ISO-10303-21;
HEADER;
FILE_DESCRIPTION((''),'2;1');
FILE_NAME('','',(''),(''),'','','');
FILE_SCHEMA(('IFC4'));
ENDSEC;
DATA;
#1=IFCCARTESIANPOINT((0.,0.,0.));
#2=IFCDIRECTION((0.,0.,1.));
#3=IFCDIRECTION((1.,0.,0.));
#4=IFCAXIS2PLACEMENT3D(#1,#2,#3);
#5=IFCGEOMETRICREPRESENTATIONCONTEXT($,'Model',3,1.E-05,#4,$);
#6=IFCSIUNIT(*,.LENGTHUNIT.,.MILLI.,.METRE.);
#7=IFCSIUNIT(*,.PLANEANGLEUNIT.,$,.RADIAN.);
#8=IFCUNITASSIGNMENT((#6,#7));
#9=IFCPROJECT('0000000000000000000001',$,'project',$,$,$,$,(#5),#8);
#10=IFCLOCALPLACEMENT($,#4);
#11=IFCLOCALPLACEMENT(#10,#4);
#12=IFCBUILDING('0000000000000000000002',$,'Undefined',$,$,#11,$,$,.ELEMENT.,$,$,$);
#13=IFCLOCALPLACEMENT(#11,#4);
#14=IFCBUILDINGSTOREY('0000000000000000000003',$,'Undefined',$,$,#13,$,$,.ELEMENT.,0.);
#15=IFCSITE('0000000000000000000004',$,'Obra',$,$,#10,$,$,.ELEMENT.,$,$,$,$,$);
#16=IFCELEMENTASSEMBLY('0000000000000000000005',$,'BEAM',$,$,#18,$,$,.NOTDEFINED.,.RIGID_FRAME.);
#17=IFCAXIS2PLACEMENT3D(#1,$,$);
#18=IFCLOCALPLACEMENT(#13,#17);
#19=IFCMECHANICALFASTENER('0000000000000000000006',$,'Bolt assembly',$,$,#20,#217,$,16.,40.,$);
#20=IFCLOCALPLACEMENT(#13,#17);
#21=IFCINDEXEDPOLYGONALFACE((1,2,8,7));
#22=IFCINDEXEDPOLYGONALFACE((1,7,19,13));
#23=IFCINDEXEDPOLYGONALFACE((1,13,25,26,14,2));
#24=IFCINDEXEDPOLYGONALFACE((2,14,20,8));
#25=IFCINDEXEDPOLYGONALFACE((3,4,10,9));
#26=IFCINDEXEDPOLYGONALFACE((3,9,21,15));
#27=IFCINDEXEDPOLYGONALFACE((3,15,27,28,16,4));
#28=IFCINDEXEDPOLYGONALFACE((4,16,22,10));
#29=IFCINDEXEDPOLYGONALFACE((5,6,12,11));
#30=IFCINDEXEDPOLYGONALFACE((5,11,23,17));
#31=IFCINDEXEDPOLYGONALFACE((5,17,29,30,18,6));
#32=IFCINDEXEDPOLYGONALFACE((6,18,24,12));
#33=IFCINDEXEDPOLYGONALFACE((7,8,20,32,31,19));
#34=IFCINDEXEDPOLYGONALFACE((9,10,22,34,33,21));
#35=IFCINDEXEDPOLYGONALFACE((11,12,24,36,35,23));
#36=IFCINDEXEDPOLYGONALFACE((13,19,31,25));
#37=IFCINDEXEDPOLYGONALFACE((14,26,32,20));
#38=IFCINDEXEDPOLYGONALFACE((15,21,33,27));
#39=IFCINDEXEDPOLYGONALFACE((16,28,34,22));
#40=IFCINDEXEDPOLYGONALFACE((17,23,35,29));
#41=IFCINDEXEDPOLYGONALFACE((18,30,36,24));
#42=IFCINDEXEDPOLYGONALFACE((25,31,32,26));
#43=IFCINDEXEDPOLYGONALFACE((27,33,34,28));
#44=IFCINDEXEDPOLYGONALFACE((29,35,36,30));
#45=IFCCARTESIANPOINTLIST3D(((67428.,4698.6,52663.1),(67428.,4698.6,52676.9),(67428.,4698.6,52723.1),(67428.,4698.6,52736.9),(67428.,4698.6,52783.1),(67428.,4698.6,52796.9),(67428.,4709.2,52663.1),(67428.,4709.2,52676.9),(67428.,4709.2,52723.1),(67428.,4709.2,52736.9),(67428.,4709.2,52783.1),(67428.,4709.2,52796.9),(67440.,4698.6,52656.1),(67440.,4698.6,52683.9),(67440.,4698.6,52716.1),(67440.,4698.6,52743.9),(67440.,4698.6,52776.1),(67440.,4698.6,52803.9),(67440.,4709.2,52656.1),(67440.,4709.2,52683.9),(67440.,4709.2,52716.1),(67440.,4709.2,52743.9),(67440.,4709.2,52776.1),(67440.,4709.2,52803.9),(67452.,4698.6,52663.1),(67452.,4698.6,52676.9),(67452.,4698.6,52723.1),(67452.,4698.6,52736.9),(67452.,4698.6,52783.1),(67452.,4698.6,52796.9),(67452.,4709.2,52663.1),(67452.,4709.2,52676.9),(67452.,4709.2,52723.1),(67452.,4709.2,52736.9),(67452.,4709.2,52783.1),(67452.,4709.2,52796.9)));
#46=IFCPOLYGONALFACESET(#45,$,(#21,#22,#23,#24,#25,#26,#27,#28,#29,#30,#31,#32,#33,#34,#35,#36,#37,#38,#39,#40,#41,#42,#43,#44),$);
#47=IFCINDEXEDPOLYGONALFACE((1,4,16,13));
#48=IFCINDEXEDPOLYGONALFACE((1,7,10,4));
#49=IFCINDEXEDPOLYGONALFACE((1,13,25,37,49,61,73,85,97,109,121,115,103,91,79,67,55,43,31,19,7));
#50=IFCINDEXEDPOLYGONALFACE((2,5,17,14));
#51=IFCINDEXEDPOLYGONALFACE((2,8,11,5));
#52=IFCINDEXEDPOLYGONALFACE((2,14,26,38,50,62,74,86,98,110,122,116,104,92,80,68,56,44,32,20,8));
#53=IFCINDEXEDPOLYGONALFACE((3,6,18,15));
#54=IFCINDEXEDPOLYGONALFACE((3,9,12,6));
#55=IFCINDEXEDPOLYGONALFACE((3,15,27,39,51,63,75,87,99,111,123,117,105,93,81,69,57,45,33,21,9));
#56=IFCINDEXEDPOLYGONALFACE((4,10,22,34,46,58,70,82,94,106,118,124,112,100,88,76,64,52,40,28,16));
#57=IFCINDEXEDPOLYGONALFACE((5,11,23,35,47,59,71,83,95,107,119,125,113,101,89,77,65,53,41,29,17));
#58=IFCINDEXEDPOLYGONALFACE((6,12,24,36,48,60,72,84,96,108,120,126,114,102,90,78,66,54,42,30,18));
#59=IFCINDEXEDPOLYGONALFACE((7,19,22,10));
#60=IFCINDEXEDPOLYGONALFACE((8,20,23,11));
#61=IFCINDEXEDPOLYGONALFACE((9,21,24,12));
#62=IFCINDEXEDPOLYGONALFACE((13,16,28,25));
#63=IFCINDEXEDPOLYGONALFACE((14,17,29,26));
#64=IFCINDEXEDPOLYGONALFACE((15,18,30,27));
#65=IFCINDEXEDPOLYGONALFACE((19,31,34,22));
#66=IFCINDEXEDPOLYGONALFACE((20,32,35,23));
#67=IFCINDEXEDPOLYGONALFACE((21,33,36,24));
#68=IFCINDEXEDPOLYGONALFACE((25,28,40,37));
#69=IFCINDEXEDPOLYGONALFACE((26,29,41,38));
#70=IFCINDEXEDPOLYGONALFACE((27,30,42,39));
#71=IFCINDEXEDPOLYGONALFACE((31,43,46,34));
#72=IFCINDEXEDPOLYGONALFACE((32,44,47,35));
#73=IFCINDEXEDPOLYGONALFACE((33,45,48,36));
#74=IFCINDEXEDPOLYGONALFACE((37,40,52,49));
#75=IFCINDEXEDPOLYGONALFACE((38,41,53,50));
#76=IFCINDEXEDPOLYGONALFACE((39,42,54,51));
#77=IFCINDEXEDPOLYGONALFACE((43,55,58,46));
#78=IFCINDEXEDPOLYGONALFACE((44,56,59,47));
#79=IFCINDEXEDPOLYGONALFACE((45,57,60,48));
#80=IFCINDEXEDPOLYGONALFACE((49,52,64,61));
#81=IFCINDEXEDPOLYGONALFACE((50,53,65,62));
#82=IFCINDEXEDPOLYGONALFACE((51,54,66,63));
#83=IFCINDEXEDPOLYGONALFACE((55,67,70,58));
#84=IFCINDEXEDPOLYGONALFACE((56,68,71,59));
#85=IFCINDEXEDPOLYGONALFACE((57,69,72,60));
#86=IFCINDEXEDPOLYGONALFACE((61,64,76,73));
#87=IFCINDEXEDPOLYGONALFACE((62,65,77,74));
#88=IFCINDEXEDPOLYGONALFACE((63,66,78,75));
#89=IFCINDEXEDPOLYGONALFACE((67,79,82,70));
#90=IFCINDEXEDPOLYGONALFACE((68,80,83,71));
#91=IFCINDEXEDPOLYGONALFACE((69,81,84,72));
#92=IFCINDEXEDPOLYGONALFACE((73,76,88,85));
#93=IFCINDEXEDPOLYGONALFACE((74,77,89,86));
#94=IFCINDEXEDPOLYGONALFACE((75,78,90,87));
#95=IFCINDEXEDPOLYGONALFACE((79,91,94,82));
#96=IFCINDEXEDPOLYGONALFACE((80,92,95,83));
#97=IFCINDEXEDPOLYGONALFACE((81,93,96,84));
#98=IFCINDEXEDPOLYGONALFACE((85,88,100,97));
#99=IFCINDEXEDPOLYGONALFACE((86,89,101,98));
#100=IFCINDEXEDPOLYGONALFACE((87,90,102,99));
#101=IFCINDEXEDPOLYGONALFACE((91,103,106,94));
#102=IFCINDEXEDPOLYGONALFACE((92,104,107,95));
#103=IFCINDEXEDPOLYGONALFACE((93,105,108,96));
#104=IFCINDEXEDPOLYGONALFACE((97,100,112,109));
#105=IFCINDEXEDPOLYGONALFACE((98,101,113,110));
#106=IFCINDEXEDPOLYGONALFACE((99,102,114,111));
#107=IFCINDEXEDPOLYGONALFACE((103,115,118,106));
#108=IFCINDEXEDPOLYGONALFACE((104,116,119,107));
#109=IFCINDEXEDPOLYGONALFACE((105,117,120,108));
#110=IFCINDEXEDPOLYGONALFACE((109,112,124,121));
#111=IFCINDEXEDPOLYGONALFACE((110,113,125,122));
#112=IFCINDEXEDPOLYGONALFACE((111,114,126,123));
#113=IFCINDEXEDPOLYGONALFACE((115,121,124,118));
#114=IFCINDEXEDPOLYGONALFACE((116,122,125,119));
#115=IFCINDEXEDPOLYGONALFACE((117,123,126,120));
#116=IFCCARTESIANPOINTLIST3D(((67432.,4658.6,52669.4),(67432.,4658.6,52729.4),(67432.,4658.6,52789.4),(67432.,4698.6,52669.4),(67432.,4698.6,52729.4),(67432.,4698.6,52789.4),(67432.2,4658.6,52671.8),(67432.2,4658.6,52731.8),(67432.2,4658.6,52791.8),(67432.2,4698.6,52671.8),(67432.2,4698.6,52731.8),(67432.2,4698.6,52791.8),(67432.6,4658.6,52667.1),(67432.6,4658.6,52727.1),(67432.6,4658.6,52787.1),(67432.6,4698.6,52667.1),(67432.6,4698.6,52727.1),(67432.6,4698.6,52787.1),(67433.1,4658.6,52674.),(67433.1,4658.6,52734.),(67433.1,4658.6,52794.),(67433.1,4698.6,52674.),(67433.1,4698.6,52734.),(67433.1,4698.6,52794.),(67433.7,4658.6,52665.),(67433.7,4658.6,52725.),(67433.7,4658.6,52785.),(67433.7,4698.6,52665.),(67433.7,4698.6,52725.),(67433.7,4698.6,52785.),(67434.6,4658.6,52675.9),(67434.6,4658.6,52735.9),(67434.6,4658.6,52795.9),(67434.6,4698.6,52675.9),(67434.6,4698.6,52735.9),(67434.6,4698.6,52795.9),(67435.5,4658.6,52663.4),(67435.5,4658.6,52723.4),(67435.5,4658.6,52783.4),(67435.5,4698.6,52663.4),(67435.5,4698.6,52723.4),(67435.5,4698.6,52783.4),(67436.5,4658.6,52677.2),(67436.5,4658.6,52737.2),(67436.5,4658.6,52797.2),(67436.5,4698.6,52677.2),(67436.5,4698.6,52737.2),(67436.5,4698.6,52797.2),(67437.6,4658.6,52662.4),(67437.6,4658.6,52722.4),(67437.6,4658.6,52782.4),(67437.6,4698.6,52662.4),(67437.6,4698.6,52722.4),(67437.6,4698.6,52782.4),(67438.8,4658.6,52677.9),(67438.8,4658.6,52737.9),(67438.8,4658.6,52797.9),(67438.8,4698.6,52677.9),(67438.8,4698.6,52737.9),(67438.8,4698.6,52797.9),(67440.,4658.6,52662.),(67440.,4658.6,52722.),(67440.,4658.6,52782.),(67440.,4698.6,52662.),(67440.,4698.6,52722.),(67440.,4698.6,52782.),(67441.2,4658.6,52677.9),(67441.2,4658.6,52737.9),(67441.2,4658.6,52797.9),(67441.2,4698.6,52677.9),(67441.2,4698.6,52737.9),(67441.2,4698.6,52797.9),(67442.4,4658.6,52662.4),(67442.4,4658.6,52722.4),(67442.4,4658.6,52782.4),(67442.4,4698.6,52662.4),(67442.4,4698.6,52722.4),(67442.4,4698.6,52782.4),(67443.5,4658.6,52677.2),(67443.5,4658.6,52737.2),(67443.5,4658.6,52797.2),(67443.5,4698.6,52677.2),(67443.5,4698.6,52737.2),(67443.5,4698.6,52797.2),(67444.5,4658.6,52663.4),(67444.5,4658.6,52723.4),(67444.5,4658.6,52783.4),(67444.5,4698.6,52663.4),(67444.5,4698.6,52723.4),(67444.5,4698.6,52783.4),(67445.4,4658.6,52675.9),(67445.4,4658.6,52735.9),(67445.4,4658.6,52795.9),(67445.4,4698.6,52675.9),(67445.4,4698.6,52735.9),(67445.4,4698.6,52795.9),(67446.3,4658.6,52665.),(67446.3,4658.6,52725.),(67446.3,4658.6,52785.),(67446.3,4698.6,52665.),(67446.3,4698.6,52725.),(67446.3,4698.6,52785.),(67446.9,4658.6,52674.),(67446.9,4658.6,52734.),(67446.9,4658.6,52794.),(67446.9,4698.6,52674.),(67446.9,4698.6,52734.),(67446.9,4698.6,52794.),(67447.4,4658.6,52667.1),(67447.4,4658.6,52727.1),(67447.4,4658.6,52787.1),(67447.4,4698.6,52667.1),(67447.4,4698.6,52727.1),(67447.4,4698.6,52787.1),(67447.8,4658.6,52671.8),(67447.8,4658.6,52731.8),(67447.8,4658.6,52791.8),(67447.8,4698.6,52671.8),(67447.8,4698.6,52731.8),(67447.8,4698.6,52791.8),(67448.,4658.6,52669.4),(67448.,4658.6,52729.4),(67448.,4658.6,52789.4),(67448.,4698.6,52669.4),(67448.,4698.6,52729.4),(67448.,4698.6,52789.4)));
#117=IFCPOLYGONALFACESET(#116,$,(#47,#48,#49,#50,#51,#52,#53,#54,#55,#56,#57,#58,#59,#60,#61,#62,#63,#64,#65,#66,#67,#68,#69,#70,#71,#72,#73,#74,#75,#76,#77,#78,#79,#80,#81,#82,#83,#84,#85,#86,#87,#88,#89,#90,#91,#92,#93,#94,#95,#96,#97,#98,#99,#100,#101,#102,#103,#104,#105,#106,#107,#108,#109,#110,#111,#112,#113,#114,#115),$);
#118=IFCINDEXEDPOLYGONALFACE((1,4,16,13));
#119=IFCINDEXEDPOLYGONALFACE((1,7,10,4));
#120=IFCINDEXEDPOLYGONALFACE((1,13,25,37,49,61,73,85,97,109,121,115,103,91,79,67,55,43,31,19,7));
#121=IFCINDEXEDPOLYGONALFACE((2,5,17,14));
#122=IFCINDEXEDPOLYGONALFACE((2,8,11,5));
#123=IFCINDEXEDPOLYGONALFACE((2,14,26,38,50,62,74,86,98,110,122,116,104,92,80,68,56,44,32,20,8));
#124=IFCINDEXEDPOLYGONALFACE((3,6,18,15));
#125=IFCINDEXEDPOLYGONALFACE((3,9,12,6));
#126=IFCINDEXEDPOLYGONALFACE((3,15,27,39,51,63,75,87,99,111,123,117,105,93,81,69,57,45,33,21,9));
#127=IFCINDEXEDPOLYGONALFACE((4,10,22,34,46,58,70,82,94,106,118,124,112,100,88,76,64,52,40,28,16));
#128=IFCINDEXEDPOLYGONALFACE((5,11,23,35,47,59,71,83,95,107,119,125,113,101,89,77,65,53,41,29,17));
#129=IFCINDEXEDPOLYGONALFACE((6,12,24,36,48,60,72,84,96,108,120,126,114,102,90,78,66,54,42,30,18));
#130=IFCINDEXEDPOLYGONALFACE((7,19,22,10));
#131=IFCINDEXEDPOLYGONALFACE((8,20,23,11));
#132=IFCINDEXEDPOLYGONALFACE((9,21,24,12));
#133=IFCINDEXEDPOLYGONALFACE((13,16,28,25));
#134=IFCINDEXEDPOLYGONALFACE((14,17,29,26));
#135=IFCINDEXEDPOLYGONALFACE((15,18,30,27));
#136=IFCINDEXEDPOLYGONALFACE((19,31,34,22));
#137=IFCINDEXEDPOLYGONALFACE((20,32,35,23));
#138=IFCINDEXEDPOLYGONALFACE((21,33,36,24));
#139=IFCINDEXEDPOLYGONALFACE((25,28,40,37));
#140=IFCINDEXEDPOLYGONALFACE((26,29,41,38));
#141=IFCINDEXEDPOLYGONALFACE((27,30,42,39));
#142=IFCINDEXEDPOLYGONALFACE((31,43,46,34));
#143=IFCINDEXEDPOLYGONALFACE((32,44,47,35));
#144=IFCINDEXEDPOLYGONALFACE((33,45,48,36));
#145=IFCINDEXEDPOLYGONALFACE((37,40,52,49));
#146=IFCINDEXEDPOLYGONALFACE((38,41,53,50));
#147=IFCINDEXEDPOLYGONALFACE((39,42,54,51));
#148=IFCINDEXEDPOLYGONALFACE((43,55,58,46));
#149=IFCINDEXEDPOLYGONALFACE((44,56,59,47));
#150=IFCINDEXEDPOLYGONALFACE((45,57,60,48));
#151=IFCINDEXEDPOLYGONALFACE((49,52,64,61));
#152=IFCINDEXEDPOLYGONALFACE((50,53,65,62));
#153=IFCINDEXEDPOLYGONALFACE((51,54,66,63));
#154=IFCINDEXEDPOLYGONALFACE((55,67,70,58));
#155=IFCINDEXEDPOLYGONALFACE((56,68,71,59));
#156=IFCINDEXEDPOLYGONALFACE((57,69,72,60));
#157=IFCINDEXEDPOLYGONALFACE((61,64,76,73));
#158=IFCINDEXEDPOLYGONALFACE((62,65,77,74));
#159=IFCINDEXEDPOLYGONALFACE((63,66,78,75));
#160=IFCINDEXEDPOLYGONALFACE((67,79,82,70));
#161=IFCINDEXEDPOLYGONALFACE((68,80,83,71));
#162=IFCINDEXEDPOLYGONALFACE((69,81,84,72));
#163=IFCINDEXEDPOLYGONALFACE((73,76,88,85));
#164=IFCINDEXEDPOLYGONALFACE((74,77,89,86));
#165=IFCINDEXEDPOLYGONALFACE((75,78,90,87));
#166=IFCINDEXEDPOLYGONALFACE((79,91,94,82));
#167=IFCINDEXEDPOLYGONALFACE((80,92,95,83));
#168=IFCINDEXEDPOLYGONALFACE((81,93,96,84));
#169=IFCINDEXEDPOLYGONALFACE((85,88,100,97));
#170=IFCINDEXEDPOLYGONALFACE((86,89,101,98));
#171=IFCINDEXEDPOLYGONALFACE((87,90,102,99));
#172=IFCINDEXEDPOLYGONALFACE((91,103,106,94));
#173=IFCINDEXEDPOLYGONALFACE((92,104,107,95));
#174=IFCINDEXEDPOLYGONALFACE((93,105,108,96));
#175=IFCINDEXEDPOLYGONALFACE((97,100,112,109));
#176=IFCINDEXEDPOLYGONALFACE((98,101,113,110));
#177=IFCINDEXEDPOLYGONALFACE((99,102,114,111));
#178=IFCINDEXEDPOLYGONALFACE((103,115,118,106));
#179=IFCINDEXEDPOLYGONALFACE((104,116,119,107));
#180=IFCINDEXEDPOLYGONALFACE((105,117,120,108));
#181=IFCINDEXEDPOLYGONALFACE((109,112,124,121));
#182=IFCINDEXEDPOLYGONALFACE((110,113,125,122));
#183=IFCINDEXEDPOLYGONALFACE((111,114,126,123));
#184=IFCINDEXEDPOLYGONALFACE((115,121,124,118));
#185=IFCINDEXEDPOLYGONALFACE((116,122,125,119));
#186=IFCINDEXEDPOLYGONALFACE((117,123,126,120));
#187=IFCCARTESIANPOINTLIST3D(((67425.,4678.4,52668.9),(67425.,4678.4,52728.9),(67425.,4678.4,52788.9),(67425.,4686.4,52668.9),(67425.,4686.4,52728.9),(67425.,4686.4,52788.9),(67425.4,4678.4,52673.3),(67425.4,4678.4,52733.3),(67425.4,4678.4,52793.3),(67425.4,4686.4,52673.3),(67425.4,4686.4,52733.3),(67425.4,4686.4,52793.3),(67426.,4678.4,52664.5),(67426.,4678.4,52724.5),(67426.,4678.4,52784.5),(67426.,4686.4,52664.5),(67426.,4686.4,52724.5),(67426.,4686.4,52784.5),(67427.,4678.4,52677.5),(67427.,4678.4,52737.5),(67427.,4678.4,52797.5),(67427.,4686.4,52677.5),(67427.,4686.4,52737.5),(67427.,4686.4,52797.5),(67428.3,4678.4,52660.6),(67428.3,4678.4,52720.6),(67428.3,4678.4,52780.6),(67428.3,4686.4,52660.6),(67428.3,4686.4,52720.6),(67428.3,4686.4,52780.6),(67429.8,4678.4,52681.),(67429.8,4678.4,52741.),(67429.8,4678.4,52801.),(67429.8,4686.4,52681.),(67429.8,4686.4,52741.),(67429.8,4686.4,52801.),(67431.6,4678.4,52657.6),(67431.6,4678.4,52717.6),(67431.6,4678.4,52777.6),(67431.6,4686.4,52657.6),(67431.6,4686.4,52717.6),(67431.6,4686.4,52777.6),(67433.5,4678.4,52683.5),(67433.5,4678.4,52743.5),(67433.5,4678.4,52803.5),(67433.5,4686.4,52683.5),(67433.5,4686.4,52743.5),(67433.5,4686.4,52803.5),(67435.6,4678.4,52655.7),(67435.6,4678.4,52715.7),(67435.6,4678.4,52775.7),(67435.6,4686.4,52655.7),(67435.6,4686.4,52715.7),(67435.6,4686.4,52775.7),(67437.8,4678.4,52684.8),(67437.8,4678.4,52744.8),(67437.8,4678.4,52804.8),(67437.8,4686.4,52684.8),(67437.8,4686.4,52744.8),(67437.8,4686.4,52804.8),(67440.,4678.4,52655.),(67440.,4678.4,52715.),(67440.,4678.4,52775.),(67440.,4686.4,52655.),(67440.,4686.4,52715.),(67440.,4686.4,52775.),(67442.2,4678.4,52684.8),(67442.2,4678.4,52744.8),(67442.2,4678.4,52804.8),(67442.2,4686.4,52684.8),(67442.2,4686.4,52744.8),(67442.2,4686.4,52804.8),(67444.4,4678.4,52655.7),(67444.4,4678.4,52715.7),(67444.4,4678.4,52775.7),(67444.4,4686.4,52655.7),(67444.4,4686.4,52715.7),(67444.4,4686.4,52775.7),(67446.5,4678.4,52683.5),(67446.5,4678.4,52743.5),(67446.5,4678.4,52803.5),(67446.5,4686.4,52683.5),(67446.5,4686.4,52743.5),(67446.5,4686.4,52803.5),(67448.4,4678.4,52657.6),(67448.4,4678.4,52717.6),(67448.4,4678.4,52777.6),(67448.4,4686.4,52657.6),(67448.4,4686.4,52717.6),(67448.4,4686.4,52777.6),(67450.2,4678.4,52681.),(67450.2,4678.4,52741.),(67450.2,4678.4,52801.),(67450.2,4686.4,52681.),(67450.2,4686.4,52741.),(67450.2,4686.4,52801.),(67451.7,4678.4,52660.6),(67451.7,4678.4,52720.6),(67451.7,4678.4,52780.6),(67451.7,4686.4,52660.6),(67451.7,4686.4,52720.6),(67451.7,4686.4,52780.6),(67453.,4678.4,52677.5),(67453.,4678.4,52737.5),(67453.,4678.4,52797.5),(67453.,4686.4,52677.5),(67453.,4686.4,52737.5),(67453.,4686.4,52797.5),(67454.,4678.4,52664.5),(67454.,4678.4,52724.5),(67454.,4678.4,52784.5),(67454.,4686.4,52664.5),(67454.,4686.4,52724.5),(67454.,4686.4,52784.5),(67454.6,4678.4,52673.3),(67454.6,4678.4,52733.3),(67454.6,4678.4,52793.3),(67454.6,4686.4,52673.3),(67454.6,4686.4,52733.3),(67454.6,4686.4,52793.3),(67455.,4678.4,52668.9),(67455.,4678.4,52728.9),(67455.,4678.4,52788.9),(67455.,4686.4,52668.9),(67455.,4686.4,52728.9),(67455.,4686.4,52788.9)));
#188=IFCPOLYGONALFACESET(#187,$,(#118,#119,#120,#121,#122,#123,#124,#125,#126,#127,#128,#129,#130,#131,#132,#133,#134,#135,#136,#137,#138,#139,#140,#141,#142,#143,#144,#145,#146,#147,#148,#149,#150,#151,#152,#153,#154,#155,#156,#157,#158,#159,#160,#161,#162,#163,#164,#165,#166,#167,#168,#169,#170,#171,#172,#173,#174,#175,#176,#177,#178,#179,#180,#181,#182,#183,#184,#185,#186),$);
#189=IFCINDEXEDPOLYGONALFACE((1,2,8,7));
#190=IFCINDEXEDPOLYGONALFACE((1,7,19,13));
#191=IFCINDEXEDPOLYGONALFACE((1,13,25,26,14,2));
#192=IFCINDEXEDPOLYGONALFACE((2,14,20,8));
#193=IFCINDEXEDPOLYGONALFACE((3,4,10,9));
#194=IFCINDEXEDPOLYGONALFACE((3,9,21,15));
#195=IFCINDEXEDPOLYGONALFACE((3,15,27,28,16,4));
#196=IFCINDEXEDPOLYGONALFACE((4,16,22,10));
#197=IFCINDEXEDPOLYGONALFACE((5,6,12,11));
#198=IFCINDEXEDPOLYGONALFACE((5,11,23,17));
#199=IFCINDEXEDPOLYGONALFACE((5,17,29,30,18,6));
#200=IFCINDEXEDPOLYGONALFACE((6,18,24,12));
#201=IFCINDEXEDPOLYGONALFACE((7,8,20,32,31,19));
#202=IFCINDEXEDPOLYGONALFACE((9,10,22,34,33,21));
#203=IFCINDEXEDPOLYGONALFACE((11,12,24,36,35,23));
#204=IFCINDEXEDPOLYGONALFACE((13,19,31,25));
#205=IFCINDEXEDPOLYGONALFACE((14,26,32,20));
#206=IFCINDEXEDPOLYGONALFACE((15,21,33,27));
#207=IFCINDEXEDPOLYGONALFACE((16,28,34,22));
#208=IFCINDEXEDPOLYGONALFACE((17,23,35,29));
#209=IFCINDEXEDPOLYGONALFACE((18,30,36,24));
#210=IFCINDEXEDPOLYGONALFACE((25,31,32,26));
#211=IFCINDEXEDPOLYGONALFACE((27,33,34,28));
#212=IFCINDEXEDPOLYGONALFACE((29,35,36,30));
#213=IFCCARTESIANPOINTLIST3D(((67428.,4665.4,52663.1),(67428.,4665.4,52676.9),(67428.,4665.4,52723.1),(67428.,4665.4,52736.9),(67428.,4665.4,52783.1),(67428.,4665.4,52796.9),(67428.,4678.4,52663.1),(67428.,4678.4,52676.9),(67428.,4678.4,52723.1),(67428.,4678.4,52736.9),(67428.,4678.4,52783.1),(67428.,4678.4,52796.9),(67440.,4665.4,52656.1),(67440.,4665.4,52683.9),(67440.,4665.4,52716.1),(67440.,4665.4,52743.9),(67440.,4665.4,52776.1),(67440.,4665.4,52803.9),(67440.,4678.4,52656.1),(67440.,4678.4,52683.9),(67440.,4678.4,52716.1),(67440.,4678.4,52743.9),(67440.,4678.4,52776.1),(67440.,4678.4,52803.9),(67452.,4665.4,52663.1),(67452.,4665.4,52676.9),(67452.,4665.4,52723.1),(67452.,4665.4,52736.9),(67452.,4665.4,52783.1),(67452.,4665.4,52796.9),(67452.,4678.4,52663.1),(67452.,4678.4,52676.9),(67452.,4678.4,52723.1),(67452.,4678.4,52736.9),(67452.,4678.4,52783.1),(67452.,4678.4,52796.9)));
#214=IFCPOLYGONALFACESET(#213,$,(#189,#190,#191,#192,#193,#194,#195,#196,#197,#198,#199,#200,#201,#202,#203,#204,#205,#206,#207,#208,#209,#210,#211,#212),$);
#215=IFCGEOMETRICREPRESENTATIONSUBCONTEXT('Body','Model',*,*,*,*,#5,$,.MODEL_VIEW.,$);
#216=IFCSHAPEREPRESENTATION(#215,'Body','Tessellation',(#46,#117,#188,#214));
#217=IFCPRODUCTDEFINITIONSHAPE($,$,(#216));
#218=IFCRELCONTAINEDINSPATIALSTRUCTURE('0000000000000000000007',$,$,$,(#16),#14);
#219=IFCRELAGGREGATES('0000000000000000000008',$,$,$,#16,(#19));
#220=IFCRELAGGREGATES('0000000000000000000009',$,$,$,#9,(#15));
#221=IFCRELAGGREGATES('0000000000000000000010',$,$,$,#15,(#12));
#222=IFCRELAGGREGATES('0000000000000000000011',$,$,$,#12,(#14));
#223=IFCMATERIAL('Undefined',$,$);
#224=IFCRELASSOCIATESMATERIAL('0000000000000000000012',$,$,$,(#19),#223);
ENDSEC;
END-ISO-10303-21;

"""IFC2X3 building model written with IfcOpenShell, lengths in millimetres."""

from ifc_helpers import new_model, si_unit, frame, origin_with_axes, origin_2d_with_axis, place, context, subcontext, project, spatial, polyline, circle, outline, extrude, source, transform, mapped, material, element, aggregate, save


model = new_model("IFC2X3")

# Units and contexts
model_context = context("Model", 3, precision=1e-05, world=origin_with_axes())
body_context = subcontext(model_context, "Body", "Model", "MODEL_VIEW")
ifc_project = project(units=[si_unit("LENGTHUNIT", "METRE", prefix="MILLI"), si_unit("PLANEANGLEUNIT", "RADIAN")], contexts=[model_context])

# Site, building, storey
site_placement = place(None, origin_with_axes())
site = spatial("IfcSite", under=ifc_project, at=site_placement, Name="Obra", CompositionType="ELEMENT")
building_placement = place(site_placement, origin_with_axes())
building = spatial("IfcBuilding", under=site, at=building_placement, Name="Undefined", CompositionType="ELEMENT")
storey_placement = place(building_placement, origin_with_axes())
storey = spatial("IfcBuildingStorey", under=building, at=storey_placement, Name="Undefined", CompositionType="ELEMENT", Elevation=0.0)

# Element assembly, mechanical fastener
ifc_material_1 = material(Name="Undefined")
shared_shape_1 = source(origin_with_axes(), body_context, "Body", "SweptSolid", [
    extrude(outline(polyline([(13.9, 0.0), (6.9, 12.0), (-6.9, 12.0), (-13.9, 0.0), (-6.9, -12.0), (6.9, -12.0), (13.9, 0.0)])), frame((0.0, -19.7, 0.0), z_axis=(0.0, 1.0, 0.0), x_axis=(1.0, 0.0, 0.0)), (0.0, 0.0, 1.0), 10.6),
    extrude(circle(Radius=8.0, at=origin_2d_with_axis()), frame((0.0, -9.1, 0.0), z_axis=(0.0, 1.0, 0.0), x_axis=(1.0, 0.0, 0.0)), (0.0, 0.0, 1.0), 40.0),
    extrude(circle(Radius=15.0, at=origin_2d_with_axis()), frame((0.0, 3.1, 0.0), z_axis=(0.0, 1.0, 0.0), x_axis=(1.0, 0.0, 0.0)), (0.0, 0.0, 1.0), 8.0),
    extrude(outline(polyline([(13.9, 0.0), (6.9, 12.0), (-6.9, 12.0), (-13.9, 0.0), (-6.9, -12.0), (6.9, -12.0), (13.9, 0.0)])), frame((0.0, 11.1, 0.0), z_axis=(0.0, 1.0, 0.0), x_axis=(1.0, 0.0, 0.0)), (0.0, 0.0, 1.0), 13.0),
])
assembly_1_placement = place(storey_placement, origin_with_axes())
assembly_1 = element("IfcElementAssembly", 1, at=assembly_1_placement, inside=storey, Name="BEAM", AssemblyPlace="NOTDEFINED", PredefinedType="RIGID_FRAME")
mechanical_fastener_1_placement = place(assembly_1_placement, frame((67490.0, 4689.5, 52850.0), z_axis=(-1.0, 0.0, 0.0), x_axis=(0.0, 0.0, -1.0)))
mechanical_fastener_1 = element("IfcMechanicalFastener", 2, at=mechanical_fastener_1_placement, material=ifc_material_1, Name="Bolt assembly", NominalDiameter=16.0, NominalLength=40.0, context=body_context, shape_type="MappedRepresentation", body=[
    mapped(shared_shape_1, transform((60.0, 0.0, 50.0))),
    mapped(shared_shape_1, transform((120.0, 0.0, 50.0))),
    mapped(shared_shape_1, transform((180.0, 0.0, 50.0))),
])
aggregate(assembly_1, [mechanical_fastener_1])

save(model, "model.ifc")
